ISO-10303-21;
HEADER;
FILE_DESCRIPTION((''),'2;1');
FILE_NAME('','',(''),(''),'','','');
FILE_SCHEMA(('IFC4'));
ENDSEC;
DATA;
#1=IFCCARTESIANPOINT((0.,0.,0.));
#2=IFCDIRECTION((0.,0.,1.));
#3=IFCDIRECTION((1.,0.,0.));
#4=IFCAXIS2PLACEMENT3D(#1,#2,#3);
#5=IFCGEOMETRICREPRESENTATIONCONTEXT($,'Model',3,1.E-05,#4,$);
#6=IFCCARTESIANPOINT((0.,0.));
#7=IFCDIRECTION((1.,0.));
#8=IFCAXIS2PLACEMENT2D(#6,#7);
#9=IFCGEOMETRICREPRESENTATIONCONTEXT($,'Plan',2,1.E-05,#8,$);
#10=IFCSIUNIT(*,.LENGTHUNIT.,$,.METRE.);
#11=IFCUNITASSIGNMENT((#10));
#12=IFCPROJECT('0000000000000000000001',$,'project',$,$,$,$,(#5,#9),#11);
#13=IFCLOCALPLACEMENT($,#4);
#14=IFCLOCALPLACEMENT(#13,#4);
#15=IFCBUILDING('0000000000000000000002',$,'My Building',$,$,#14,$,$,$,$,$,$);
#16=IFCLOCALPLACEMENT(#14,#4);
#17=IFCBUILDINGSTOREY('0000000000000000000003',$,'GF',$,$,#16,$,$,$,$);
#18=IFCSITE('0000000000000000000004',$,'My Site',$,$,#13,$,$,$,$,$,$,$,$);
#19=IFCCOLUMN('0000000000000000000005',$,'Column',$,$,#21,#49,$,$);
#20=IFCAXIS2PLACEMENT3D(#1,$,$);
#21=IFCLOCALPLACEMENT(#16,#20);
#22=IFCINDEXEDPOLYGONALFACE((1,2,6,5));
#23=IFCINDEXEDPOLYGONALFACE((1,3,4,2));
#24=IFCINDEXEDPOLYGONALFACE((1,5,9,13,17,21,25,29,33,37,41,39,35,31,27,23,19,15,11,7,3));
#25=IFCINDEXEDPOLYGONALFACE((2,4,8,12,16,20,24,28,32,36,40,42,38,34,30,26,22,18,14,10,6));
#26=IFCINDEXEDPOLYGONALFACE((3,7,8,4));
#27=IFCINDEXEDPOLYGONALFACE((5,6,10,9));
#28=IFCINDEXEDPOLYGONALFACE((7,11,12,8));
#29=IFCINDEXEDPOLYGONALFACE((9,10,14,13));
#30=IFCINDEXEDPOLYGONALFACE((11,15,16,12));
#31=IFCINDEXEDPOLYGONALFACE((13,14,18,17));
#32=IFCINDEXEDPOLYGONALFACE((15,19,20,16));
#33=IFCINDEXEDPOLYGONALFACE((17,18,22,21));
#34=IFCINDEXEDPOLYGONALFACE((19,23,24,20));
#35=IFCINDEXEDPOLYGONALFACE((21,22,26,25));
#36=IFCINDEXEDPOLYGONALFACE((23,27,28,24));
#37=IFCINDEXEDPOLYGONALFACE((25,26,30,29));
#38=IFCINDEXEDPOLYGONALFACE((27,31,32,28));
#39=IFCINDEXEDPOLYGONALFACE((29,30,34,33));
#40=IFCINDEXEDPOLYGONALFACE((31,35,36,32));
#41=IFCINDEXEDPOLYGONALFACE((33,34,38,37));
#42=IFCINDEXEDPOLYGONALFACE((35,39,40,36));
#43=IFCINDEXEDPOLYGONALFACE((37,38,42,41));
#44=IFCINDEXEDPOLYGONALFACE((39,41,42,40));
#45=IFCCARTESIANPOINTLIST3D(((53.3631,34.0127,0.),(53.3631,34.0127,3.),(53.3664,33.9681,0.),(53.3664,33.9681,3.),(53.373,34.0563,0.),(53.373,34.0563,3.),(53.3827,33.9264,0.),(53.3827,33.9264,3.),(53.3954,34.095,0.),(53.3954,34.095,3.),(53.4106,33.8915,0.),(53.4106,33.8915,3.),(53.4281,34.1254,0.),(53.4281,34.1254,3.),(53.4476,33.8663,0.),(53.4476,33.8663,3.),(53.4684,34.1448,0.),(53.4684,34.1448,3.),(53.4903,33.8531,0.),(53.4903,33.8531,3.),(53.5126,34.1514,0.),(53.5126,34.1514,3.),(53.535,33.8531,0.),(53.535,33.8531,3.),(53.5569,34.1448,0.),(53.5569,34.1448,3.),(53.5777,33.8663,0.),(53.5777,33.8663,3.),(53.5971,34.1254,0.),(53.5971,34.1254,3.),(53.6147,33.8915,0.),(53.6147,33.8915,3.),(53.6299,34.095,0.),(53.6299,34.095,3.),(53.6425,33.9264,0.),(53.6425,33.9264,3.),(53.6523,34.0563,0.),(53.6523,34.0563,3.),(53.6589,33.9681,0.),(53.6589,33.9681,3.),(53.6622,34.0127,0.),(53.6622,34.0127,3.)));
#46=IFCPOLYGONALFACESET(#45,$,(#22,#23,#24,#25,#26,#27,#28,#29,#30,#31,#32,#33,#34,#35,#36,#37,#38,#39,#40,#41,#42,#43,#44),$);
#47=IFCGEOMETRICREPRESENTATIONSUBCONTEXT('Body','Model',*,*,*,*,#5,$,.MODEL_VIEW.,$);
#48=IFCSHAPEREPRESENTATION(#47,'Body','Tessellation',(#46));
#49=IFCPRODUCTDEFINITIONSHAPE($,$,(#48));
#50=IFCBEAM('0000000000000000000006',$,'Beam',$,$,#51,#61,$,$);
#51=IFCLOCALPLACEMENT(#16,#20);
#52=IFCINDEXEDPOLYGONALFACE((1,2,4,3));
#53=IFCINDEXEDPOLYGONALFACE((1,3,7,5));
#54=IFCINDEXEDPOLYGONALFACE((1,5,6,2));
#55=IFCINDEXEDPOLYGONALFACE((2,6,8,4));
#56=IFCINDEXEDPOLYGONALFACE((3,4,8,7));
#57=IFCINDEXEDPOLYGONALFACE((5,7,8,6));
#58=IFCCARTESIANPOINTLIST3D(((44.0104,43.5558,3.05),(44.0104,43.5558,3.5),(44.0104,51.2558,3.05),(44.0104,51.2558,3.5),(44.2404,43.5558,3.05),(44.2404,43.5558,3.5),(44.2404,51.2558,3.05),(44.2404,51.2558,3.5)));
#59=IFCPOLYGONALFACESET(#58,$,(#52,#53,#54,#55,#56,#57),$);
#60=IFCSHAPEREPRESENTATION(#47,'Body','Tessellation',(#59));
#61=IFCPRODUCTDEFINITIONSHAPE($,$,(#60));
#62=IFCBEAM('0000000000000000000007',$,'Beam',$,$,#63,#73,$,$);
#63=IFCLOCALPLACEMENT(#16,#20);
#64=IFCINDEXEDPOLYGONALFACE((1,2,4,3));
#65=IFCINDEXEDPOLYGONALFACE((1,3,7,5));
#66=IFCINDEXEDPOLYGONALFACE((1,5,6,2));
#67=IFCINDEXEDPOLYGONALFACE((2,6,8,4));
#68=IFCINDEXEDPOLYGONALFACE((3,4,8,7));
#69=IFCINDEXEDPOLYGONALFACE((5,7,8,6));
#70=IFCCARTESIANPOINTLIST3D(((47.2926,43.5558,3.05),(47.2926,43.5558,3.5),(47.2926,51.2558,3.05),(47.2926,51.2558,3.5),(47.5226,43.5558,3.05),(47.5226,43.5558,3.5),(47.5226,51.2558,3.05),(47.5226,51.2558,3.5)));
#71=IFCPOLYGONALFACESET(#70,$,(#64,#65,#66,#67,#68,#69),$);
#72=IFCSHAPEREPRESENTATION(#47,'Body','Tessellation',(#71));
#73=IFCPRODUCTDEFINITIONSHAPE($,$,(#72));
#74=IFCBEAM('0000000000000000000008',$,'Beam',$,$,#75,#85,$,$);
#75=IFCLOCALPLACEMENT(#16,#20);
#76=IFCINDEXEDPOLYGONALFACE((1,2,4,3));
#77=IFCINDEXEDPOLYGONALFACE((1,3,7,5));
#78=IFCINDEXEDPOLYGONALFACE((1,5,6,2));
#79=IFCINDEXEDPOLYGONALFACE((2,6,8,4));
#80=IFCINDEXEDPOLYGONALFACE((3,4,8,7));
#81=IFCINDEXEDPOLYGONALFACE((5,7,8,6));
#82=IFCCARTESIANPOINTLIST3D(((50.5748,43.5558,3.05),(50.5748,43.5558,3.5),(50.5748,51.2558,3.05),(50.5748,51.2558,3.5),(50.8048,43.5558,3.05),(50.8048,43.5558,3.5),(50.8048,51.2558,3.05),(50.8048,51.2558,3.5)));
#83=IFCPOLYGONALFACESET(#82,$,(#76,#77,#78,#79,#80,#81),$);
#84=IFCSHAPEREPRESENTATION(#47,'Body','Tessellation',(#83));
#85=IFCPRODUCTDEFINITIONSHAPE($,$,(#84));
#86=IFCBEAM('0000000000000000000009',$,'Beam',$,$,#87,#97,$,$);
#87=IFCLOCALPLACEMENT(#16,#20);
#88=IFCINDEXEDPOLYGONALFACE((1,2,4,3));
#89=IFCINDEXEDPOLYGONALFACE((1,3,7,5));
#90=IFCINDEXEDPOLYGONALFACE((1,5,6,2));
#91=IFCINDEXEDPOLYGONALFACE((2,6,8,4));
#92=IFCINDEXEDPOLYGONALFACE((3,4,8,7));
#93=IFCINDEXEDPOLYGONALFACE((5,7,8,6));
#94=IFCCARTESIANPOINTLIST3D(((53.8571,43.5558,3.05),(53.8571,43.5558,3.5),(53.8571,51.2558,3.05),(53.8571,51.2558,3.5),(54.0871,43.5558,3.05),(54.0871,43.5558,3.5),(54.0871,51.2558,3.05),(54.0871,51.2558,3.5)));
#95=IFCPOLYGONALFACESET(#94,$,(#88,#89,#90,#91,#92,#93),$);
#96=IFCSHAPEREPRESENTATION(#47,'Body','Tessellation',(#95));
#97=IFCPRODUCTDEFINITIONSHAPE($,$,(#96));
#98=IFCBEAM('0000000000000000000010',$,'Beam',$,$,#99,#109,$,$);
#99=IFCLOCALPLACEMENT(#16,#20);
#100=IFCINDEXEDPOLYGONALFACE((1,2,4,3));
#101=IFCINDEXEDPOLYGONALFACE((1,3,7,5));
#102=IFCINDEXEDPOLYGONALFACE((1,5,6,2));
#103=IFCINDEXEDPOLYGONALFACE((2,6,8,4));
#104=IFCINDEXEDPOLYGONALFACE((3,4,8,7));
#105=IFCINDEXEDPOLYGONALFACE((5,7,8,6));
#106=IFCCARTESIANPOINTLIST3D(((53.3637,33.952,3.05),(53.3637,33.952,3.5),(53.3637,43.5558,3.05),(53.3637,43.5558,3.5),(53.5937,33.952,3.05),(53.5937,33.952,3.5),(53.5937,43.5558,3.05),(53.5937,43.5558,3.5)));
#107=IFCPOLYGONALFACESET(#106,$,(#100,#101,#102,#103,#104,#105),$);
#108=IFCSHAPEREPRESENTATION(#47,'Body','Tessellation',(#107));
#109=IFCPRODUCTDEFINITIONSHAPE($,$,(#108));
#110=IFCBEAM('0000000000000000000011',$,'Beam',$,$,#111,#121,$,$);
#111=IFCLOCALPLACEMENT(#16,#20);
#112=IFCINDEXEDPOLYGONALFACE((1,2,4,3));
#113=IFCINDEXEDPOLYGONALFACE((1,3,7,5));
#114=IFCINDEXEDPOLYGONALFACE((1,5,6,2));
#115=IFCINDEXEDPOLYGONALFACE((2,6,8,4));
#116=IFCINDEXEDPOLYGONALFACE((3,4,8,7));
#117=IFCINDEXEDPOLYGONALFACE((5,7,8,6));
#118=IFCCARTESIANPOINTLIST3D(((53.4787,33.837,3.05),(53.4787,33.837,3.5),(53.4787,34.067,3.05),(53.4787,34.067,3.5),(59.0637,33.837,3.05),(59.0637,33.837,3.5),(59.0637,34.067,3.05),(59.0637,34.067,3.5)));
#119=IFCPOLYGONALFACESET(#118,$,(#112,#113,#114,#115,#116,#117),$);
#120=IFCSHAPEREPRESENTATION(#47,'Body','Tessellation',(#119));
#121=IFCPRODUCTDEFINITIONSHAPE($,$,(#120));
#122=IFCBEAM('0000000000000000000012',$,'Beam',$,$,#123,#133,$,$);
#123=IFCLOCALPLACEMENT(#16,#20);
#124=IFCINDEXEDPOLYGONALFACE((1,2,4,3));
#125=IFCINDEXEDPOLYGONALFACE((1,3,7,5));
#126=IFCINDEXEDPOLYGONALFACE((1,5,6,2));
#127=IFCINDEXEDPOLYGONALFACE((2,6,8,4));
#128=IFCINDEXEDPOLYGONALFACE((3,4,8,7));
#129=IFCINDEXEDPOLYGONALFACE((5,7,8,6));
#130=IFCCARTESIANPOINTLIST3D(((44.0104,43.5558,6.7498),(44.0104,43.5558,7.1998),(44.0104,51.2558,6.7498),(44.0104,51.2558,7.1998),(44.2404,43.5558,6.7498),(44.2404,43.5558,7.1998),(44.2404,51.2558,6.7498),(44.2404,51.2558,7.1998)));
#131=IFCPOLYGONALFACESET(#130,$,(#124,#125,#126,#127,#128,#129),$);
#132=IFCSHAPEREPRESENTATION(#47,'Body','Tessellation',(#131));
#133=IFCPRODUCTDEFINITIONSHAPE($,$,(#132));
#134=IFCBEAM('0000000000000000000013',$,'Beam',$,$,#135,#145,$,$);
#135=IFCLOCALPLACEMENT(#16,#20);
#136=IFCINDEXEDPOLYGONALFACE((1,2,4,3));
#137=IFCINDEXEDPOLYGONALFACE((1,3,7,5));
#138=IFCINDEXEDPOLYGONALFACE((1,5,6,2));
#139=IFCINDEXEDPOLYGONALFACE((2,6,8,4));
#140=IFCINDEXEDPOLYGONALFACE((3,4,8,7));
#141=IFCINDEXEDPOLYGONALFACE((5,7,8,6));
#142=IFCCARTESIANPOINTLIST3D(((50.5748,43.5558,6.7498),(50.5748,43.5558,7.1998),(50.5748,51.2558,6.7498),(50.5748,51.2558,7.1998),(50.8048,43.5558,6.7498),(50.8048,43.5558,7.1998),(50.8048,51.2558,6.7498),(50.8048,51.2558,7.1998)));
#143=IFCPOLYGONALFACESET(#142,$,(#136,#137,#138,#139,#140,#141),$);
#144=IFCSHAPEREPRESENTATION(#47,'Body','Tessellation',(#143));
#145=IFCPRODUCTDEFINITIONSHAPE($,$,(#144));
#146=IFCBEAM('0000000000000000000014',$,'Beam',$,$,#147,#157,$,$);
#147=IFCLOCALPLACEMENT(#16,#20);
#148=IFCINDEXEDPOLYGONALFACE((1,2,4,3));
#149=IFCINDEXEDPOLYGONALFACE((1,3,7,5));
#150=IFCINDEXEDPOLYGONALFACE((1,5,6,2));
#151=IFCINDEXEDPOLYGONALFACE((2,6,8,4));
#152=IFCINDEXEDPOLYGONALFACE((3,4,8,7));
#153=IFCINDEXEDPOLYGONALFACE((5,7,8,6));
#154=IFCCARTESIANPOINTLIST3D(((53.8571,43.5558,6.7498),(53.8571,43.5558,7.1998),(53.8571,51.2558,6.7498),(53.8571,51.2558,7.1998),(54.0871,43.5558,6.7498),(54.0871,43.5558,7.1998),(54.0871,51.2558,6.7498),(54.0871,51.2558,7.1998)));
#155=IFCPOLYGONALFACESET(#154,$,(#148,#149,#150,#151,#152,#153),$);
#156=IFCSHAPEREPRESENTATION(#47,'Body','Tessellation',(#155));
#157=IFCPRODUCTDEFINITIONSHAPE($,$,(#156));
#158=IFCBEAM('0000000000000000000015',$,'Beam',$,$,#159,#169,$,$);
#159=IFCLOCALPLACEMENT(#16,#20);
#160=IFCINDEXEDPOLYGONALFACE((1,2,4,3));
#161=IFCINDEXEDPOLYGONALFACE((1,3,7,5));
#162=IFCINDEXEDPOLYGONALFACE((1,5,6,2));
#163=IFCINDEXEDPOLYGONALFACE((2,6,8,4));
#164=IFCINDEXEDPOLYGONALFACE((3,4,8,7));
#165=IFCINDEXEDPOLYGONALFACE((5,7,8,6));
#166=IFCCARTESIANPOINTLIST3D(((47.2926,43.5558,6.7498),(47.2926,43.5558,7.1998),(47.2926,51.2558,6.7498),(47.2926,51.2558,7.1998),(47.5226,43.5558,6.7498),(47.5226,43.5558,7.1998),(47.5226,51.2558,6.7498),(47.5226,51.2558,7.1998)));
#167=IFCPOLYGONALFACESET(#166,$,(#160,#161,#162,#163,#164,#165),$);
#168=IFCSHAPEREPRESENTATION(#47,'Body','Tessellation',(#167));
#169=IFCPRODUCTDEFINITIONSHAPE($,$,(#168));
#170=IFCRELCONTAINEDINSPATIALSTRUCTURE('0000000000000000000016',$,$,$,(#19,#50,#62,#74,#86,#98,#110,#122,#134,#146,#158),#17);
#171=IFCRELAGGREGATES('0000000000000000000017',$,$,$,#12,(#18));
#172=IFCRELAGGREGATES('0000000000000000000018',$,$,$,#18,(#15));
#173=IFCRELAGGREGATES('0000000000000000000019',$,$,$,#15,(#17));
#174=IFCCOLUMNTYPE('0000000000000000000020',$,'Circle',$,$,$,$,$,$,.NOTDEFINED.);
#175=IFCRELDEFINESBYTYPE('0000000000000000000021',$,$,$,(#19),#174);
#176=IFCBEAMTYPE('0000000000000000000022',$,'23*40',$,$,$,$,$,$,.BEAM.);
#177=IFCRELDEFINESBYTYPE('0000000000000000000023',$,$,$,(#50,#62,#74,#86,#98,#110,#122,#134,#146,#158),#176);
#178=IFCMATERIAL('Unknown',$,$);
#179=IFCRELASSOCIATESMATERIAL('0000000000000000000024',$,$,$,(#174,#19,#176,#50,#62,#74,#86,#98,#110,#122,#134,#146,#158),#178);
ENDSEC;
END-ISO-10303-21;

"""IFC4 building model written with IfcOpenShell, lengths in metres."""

from ifc_helpers import new_model, si_unit, frame, origin_with_axes, origin_2d_with_axis, place, context, subcontext, project, spatial, rectangle, circle, extrude, material, material_profile, profile_set, profile_usage, type_object, element, save


model = new_model("IFC4")

# Units and contexts
model_context = context("Model", 3, precision=1e-05, world=origin_with_axes())
plan_context = context("Plan", 2, precision=1e-05, world=origin_2d_with_axis())
body_context = subcontext(model_context, "Body", "Model", "MODEL_VIEW")
ifc_project = project(units=[si_unit("LENGTHUNIT", "METRE")], contexts=[model_context, plan_context])

# Site, building, storey
site_placement = place(None, origin_with_axes())
site = spatial("IfcSite", under=ifc_project, at=site_placement, Name="My Site")
building_placement = place(site_placement, origin_with_axes())
building = spatial("IfcBuilding", under=site, at=building_placement, Name="My Building")
storey_placement = place(building_placement, origin_with_axes())
storey = spatial("IfcBuildingStorey", under=building, at=storey_placement, Name="GF")

# Column
ifc_material = material(Name="Unknown")
ifc_material_profile_1 = material_profile(ifc_material, circle(Radius=0.15))
ifc_profile_set_1 = profile_set([ifc_material_profile_1])
column_type_1 = type_object("IfcColumnType", Name="Circle", PredefinedType="NOTDEFINED", material=ifc_profile_set_1)
ifc_profile_usage_1 = profile_usage(ifc_profile_set_1, cardinal=5)
column_1_placement = place(storey_placement, frame((53.5126, 34.0014, 0.0), z_axis=(0.0, 0.0, 1.0), x_axis=(0.0, 1.0, 0.0)))
element("IfcColumn", 1, at=column_1_placement, inside=storey, type_object=column_type_1, material=ifc_profile_usage_1, Name="Column", context=body_context, shape_type="SweptSolid", body=[
    extrude(circle(Radius=0.15), origin_with_axes(), (0.0, 0.0, 1.0), 3.0),
])

# Beams
ifc_material_profile_2 = material_profile(ifc_material, rectangle(XDim=0.23, YDim=0.45))
ifc_profile_set_2 = profile_set([ifc_material_profile_2])
ifc_profile_usage_2 = profile_usage(ifc_profile_set_2, cardinal=5)
beam_type = type_object("IfcBeamType", Name="23*40", PredefinedType="BEAM", material=ifc_profile_set_2)
beam_1_placement = place(storey_placement, frame((44.1254, 43.5558, 3.275), z_axis=(0.0, 1.0, 0.0), x_axis=(-1.0, 0.0, 0.0)))
element("IfcBeam", 2, at=beam_1_placement, inside=storey, type_object=beam_type, material=ifc_profile_usage_2, Name="Beam", context=body_context, shape_type="SweptSolid", body=[
    extrude(rectangle(XDim=0.23, YDim=0.45), origin_with_axes(), (0.0, 0.0, 1.0), 7.7),
])
ifc_profile_usage_3 = profile_usage(ifc_profile_set_2, cardinal=5)
beam_2_placement = place(storey_placement, frame((47.4076, 43.5558, 3.275), z_axis=(0.0, 1.0, 0.0), x_axis=(-1.0, 0.0, 0.0)))
element("IfcBeam", 3, at=beam_2_placement, inside=storey, type_object=beam_type, material=ifc_profile_usage_3, Name="Beam", context=body_context, shape_type="SweptSolid", body=[
    extrude(rectangle(XDim=0.23, YDim=0.45), origin_with_axes(), (0.0, 0.0, 1.0), 7.7),
])
ifc_profile_usage_4 = profile_usage(ifc_profile_set_2, cardinal=5)
beam_3_placement = place(storey_placement, frame((50.6898, 43.5558, 3.275), z_axis=(0.0, 1.0, 0.0), x_axis=(-1.0, 0.0, 0.0)))
element("IfcBeam", 4, at=beam_3_placement, inside=storey, type_object=beam_type, material=ifc_profile_usage_4, Name="Beam", context=body_context, shape_type="SweptSolid", body=[
    extrude(rectangle(XDim=0.23, YDim=0.45), origin_with_axes(), (0.0, 0.0, 1.0), 7.7),
])
ifc_profile_usage_5 = profile_usage(ifc_profile_set_2, cardinal=5)
beam_4_placement = place(storey_placement, frame((53.9721, 43.5558, 3.275), z_axis=(0.0, 1.0, 0.0), x_axis=(-1.0, 0.0, 0.0)))
element("IfcBeam", 5, at=beam_4_placement, inside=storey, type_object=beam_type, material=ifc_profile_usage_5, Name="Beam", context=body_context, shape_type="SweptSolid", body=[
    extrude(rectangle(XDim=0.23, YDim=0.45), origin_with_axes(), (0.0, 0.0, 1.0), 7.7),
])
ifc_profile_usage_6 = profile_usage(ifc_profile_set_2, cardinal=5)
beam_5_placement = place(storey_placement, frame((53.4787, 33.952, 3.275), z_axis=(0.000001, 1.0, 0.0), x_axis=(-1.0, 0.000001, 0.0)))
element("IfcBeam", 6, at=beam_5_placement, inside=storey, type_object=beam_type, material=ifc_profile_usage_6, Name="Beam", context=body_context, shape_type="SweptSolid", body=[
    extrude(rectangle(XDim=0.23, YDim=0.45), origin_with_axes(), (0.0, 0.0, 1.0), 9.6038),
])
ifc_profile_usage_7 = profile_usage(ifc_profile_set_2, cardinal=5)
beam_6_placement = place(storey_placement, frame((53.4787, 33.952, 3.275), z_axis=(1.0, -0.000001, 0.0), x_axis=(0.000001, 1.0, 0.0)))
element("IfcBeam", 7, at=beam_6_placement, inside=storey, type_object=beam_type, material=ifc_profile_usage_7, Name="Beam", context=body_context, shape_type="SweptSolid", body=[
    extrude(rectangle(XDim=0.23, YDim=0.45), origin_with_axes(), (0.0, 0.0, 1.0), 5.585),
])
ifc_profile_usage_8 = profile_usage(ifc_profile_set_2, cardinal=5)
beam_7_placement = place(storey_placement, frame((44.1254, 43.5558, 6.9748), z_axis=(0.0, 1.0, 0.0), x_axis=(-1.0, 0.0, 0.0)))
element("IfcBeam", 8, at=beam_7_placement, inside=storey, type_object=beam_type, material=ifc_profile_usage_8, Name="Beam", context=body_context, shape_type="SweptSolid", body=[
    extrude(rectangle(XDim=0.23, YDim=0.45), origin_with_axes(), (0.0, 0.0, 1.0), 7.7),
])
ifc_profile_usage_9 = profile_usage(ifc_profile_set_2, cardinal=5)
beam_8_placement = place(storey_placement, frame((50.6898, 43.5558, 6.9748), z_axis=(0.0, 1.0, 0.0), x_axis=(-1.0, 0.0, 0.0)))
element("IfcBeam", 9, at=beam_8_placement, inside=storey, type_object=beam_type, material=ifc_profile_usage_9, Name="Beam", context=body_context, shape_type="SweptSolid", body=[
    extrude(rectangle(XDim=0.23, YDim=0.45), origin_with_axes(), (0.0, 0.0, 1.0), 7.7),
])
ifc_profile_usage_10 = profile_usage(ifc_profile_set_2, cardinal=5)
beam_9_placement = place(storey_placement, frame((53.9721, 43.5558, 6.9748), z_axis=(0.0, 1.0, 0.0), x_axis=(-1.0, 0.0, 0.0)))
element("IfcBeam", 10, at=beam_9_placement, inside=storey, type_object=beam_type, material=ifc_profile_usage_10, Name="Beam", context=body_context, shape_type="SweptSolid", body=[
    extrude(rectangle(XDim=0.23, YDim=0.45), origin_with_axes(), (0.0, 0.0, 1.0), 7.7),
])
ifc_profile_usage_11 = profile_usage(ifc_profile_set_2, cardinal=5)
beam_10_placement = place(storey_placement, frame((47.4076, 43.5558, 6.9748), z_axis=(0.0, 1.0, 0.0), x_axis=(-1.0, 0.0, 0.0)))
element("IfcBeam", 11, at=beam_10_placement, inside=storey, type_object=beam_type, material=ifc_profile_usage_11, Name="Beam", context=body_context, shape_type="SweptSolid", body=[
    extrude(rectangle(XDim=0.23, YDim=0.45), origin_with_axes(), (0.0, 0.0, 1.0), 7.7),
])

save(model, "model.ifc")
